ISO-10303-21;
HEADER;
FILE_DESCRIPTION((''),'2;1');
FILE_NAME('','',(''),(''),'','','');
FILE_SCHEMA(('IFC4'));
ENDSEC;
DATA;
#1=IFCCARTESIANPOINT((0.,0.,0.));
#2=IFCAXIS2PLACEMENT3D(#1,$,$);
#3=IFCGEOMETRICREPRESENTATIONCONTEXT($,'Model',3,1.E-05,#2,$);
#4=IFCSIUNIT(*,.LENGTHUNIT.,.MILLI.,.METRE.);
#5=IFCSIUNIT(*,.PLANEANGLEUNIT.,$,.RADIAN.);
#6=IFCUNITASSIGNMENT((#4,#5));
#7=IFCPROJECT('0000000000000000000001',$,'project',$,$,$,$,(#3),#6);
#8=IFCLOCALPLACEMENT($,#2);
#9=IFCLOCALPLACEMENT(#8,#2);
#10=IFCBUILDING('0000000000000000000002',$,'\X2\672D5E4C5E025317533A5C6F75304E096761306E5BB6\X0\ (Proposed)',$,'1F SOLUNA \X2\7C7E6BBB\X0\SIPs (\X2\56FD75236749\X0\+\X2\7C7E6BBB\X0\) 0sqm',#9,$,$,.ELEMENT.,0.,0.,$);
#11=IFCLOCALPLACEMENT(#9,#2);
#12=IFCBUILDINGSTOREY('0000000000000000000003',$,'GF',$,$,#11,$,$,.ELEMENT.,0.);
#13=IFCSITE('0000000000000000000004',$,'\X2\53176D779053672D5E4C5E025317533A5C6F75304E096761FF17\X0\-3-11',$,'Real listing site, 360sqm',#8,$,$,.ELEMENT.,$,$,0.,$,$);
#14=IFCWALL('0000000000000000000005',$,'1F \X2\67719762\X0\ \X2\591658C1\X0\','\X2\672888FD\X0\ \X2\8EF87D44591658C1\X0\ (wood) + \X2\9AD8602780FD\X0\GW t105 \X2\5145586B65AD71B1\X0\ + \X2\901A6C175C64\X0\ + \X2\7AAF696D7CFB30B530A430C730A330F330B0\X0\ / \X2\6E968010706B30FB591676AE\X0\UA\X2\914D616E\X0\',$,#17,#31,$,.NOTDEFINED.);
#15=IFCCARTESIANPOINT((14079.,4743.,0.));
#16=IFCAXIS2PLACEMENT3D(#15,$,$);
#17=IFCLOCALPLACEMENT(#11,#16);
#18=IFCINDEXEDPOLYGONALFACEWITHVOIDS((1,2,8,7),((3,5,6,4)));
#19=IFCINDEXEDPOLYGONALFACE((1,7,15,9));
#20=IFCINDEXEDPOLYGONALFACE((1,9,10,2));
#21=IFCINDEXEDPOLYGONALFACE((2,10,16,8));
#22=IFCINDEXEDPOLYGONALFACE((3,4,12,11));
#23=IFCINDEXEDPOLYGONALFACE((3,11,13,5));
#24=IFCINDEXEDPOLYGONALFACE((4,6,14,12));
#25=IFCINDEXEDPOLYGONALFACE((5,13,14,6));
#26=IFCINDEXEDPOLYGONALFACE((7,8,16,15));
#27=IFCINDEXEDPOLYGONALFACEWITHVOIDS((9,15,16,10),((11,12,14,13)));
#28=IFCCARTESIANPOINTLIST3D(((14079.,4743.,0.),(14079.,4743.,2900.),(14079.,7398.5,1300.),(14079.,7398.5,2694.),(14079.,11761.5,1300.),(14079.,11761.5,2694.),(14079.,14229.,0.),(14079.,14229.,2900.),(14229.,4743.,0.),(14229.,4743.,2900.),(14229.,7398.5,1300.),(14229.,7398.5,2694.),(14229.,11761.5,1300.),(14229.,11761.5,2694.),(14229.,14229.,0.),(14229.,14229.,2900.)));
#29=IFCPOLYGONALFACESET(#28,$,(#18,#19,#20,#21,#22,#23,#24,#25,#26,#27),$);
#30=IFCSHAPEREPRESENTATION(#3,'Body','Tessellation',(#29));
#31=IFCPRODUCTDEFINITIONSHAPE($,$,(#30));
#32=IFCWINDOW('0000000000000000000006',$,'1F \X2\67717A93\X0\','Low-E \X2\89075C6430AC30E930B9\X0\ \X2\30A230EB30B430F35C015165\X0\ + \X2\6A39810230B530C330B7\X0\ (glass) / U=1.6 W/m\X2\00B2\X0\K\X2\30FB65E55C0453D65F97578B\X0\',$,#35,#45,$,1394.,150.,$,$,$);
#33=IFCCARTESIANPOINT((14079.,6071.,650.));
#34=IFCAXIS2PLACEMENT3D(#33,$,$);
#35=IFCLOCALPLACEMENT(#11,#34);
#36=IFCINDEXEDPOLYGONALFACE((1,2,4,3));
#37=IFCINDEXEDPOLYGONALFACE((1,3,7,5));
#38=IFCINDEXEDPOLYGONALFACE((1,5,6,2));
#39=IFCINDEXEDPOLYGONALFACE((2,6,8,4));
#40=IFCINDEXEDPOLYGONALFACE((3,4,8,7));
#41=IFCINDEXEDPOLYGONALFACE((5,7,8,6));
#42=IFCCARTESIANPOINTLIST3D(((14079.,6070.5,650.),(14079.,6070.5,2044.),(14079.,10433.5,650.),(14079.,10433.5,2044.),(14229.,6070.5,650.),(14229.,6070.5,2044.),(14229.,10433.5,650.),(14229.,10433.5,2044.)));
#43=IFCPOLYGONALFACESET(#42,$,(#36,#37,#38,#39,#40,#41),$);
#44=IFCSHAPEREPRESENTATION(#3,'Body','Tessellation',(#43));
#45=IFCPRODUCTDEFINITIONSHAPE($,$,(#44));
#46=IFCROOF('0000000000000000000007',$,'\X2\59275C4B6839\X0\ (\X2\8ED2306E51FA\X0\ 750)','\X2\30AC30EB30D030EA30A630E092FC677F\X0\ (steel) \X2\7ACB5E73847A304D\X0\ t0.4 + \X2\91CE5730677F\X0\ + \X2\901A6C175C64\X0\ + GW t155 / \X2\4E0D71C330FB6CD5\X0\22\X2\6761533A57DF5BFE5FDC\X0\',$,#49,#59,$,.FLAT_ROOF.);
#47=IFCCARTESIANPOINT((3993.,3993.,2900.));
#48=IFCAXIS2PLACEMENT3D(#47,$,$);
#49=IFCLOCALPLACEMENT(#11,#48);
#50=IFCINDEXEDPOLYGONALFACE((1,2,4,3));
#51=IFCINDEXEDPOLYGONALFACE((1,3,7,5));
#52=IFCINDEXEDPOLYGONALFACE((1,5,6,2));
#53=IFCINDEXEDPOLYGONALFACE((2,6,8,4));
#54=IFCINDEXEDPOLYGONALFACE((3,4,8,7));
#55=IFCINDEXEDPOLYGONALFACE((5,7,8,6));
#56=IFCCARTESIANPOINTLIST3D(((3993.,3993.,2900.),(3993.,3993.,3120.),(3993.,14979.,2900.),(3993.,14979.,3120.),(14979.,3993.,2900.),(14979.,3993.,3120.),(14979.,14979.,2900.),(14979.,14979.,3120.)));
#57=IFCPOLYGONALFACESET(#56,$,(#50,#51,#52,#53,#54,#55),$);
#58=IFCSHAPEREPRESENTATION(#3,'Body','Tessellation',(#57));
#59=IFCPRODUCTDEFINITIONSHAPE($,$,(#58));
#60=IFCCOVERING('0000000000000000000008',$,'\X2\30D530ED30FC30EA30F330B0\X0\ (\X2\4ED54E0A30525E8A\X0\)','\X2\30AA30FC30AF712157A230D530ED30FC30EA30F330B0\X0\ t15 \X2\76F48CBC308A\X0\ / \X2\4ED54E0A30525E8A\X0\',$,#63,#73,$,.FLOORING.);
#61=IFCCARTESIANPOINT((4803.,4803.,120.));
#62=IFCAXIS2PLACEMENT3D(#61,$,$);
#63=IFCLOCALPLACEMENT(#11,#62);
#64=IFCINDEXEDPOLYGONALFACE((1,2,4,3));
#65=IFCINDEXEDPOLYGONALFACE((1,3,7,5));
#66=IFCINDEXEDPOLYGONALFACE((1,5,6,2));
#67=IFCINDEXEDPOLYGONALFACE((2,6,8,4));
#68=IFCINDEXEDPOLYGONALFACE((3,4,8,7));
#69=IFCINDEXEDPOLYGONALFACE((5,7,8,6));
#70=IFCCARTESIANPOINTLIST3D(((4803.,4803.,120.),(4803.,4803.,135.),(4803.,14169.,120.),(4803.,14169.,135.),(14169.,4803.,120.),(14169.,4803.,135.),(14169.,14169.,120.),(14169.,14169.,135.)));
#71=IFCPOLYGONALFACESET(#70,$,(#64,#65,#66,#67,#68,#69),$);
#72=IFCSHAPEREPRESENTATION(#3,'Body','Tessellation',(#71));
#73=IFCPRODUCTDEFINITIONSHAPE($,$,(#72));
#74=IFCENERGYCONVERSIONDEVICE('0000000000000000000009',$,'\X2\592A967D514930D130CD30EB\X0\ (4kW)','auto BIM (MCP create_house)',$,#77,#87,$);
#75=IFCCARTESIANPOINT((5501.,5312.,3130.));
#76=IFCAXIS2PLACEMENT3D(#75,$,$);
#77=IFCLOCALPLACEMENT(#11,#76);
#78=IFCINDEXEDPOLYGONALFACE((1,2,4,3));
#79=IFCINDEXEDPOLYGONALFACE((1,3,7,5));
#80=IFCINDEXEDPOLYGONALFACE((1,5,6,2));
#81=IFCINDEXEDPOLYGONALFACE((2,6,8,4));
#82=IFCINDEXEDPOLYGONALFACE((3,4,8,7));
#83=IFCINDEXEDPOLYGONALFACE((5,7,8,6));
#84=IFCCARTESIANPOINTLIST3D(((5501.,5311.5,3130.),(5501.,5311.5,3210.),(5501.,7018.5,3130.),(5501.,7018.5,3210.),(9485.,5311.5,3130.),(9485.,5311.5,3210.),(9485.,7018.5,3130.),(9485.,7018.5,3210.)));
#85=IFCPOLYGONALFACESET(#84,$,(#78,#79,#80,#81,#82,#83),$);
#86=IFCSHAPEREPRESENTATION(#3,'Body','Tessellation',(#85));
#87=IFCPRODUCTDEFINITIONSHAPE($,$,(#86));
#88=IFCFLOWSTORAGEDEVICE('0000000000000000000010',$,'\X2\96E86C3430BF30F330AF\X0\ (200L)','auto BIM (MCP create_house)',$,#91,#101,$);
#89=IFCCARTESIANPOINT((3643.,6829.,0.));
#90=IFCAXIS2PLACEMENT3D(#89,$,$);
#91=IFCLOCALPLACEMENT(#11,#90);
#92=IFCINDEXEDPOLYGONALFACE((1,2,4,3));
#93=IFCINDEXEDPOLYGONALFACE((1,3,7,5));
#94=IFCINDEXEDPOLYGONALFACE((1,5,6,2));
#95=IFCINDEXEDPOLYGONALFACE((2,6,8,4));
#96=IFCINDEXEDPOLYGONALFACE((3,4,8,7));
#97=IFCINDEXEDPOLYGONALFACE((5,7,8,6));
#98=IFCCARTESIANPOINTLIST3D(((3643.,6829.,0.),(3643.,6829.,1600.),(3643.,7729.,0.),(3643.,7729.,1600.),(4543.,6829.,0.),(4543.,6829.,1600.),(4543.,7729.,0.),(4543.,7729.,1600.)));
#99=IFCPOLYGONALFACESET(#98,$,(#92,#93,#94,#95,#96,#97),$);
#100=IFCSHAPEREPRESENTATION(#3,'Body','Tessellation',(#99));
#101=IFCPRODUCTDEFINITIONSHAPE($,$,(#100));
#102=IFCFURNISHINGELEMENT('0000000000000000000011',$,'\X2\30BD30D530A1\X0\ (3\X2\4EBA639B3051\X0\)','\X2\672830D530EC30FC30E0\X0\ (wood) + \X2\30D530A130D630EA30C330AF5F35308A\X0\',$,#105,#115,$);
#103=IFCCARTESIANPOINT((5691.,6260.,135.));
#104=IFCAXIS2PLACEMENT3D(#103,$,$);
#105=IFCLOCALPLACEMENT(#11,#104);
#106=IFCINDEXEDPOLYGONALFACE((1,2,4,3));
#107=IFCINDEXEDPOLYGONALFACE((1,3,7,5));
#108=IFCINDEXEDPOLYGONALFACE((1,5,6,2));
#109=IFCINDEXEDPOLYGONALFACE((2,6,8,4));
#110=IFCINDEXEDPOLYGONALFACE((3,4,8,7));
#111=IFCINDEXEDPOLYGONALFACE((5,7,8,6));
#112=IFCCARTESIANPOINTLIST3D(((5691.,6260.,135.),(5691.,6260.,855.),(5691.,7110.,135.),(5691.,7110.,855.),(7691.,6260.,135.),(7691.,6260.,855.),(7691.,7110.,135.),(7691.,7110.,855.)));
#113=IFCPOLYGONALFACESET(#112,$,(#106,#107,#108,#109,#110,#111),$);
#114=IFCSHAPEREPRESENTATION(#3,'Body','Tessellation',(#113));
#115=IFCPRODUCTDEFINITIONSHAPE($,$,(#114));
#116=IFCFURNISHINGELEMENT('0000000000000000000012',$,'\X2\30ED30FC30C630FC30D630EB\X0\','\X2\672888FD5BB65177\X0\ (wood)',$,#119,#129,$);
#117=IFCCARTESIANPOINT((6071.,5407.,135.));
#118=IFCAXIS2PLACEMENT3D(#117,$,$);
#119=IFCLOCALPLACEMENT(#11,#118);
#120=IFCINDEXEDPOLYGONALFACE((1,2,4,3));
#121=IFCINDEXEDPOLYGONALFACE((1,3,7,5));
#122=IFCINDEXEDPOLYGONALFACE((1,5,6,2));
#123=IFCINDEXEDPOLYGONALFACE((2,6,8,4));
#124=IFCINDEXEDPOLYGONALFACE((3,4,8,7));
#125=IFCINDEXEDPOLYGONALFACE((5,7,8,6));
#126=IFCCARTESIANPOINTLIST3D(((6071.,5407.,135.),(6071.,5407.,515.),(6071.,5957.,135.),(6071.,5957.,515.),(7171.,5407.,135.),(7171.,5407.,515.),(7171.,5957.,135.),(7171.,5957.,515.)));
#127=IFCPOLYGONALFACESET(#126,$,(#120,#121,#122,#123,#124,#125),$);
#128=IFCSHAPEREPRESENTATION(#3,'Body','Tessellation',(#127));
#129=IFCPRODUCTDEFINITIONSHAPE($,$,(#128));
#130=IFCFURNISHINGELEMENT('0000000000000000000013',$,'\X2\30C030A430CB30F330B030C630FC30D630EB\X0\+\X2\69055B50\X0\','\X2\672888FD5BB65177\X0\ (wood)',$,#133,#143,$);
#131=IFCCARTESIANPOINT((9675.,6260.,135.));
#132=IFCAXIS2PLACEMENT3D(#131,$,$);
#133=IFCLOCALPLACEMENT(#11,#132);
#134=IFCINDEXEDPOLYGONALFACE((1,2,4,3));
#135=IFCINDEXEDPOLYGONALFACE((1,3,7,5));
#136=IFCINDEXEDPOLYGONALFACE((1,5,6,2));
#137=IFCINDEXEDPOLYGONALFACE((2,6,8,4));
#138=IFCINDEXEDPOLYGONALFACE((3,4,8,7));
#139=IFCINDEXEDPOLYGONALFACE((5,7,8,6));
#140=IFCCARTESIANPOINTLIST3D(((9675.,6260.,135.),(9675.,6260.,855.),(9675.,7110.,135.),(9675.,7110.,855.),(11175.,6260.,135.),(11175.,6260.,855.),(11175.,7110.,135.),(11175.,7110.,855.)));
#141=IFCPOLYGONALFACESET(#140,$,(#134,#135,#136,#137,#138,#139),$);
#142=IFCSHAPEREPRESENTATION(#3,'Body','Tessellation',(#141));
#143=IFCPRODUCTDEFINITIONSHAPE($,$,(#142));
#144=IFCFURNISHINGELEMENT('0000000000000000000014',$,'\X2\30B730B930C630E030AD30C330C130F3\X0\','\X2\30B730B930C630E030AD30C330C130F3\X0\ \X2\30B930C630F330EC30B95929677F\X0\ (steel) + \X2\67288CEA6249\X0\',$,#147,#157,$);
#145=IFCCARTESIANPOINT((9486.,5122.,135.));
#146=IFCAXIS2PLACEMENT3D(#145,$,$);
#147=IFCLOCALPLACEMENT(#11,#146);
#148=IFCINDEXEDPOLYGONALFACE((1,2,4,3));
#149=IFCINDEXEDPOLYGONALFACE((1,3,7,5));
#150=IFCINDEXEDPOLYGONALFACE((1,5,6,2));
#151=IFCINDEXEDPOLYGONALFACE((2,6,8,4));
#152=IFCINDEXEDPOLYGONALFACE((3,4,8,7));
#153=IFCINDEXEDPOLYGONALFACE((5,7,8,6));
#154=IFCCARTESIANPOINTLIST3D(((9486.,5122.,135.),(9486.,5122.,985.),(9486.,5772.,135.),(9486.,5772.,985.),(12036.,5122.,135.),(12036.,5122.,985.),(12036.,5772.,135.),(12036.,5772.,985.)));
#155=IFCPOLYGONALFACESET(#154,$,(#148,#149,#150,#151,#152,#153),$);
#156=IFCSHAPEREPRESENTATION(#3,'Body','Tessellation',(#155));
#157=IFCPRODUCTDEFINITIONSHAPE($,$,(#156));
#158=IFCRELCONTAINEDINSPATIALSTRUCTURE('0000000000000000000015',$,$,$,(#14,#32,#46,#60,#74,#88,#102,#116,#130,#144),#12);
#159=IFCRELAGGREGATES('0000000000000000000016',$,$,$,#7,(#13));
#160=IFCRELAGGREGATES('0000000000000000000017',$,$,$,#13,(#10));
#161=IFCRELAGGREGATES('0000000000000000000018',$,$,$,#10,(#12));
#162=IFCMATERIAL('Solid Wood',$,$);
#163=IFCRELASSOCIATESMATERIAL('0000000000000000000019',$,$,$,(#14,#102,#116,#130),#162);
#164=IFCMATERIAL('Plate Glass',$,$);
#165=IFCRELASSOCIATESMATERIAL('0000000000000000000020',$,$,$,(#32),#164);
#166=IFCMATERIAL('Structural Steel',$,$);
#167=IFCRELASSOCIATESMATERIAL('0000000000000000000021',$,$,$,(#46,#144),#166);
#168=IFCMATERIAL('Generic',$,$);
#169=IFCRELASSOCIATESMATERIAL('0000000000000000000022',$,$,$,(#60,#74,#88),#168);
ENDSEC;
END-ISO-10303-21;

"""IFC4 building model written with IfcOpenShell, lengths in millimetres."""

from ifc_helpers import new_model, si_unit, frame, frame_2d, origin, place, context, project, spatial, rectangle, extrude, material, element, fill, save


model = new_model("IFC4")

# Units and contexts
model_context = context("Model", 3, precision=1e-05, world=origin())
ifc_project = project(units=[si_unit("LENGTHUNIT", "METRE", prefix="MILLI"), si_unit("PLANEANGLEUNIT", "RADIAN")], contexts=[model_context])

# Site, building, storey
site_placement = place(None, origin())
site = spatial("IfcSite", under=ifc_project, at=site_placement, Name="北海道札幌市北区屯田三条７-3-11", ObjectType="Real listing site, 360sqm", CompositionType="ELEMENT", RefElevation=0.0)
building_placement = place(site_placement, origin())
building = spatial("IfcBuilding", under=site, at=building_placement, Name="札幌市北区屯田三条の家 (Proposed)", ObjectType="1F SOLUNA 籾殻SIPs (国産杉+籾殻) 0sqm", CompositionType="ELEMENT", ElevationOfRefHeight=0.0, ElevationOfTerrain=0.0)
storey_placement = place(building_placement, origin())
storey = spatial("IfcBuildingStorey", under=building, at=storey_placement, Name="GF", CompositionType="ELEMENT", Elevation=0.0)

# Shared definitions
ifc_material_1 = material(Name="Solid Wood")

# Shared definitions
ifc_material_2 = material(Name="Plate Glass")

# Wall, opening, window
wall_1_placement = place(storey_placement, frame((14079.0, 4743.0, 0.0)))
wall_1 = element("IfcWall", 1, at=wall_1_placement, inside=storey, material=ifc_material_1, Name="1F 東面 外壁", Description="木製 軸組外壁 (wood) + 高性能GW t105 充填断熱 + 通気層 + 窯業系サイディング / 準耐火・外皮UA配慮", PredefinedType="NOTDEFINED", context=model_context, shape_type="SweptSolid", body=[
    extrude(rectangle(XDim=150.0, YDim=9486.0, at=frame_2d((75.0, 4743.0))), frame((14079.0, 4743.0, 0.0)), (0.0, 0.0, 1.0), 2900.0),
])
opening_1_placement = place(storey_placement, frame((14079.0, 6071.0, 650.0)))
opening_1 = element("IfcOpeningElement", 2, at=opening_1_placement, cuts=wall_1, PredefinedType="NOTDEFINED", context=model_context, shape_type="SweptSolid", body=[
    extrude(rectangle(XDim=150.0, YDim=4363.0, at=frame_2d((75.0, 2181.0))), frame((14079.0, 6071.0, 650.0)), (0.0, 0.0, 1.0), 1394.0),
])
window_1_placement = place(storey_placement, frame((14079.0, 6071.0, 650.0)))
window_1 = element("IfcWindow", 3, at=window_1_placement, inside=storey, material=ifc_material_2, Name="1F 東窓", Description="Low-E 複層ガラス アルゴン封入 + 樹脂サッシ (glass) / U=1.6 W/m²K・日射取得型", OverallHeight=1394.0, OverallWidth=150.0, context=model_context, shape_type="SweptSolid", body=[
    extrude(rectangle(XDim=150.0, YDim=4363.0, at=frame_2d((75.0, 2181.0))), frame((14079.0, 6071.0, 650.0)), (0.0, 0.0, 1.0), 1394.0),
])
fill(opening_1, window_1)

# Roof
ifc_material_3 = material(Name="Structural Steel")
roof_placement = place(storey_placement, frame((3993.0, 3993.0, 2900.0)))
element("IfcRoof", 4, at=roof_placement, inside=storey, material=ifc_material_3, Name="大屋根 (軒の出 750)", Description="ガルバリウム鋼板 (steel) 立平葺き t0.4 + 野地板 + 通気層 + GW t155 / 不燃・法22条区域対応", PredefinedType="FLAT_ROOF", context=model_context, shape_type="SweptSolid", body=[
    extrude(rectangle(XDim=10986.0, YDim=10986.0, at=frame_2d((5493.0, 5493.0))), frame((3993.0, 3993.0, 2900.0)), (0.0, 0.0, 1.0), 220.0),
])

# Covering
ifc_material_4 = material(Name="Generic")
covering_placement = place(storey_placement, frame((4803.0, 4803.0, 120.0)))
element("IfcCovering", 5, at=covering_placement, inside=storey, material=ifc_material_4, Name="フローリング (仕上げ床)", Description="オーク無垢フローリング t15 直貼り / 仕上げ床", PredefinedType="FLOORING", context=model_context, shape_type="SweptSolid", body=[
    extrude(rectangle(XDim=9366.0, YDim=9366.0, at=frame_2d((4683.0, 4683.0))), frame((4803.0, 4803.0, 120.0)), (0.0, 0.0, 1.0), 15.0),
])

# Energy conversion device
energy_conversion_device_placement = place(storey_placement, frame((5501.0, 5312.0, 3130.0)))
element("IfcEnergyConversionDevice", 6, at=energy_conversion_device_placement, inside=storey, material=ifc_material_4, Name="太陽光パネル (4kW)", Description="auto BIM (MCP create_house)", context=model_context, shape_type="SweptSolid", body=[
    extrude(rectangle(XDim=3984.0, YDim=1707.0, at=frame_2d((1992.0, 853.0))), frame((5501.0, 5312.0, 3130.0)), (0.0, 0.0, 1.0), 80.0),
])

# Flow storage device
flow_storage_device_placement = place(storey_placement, frame((3643.0, 6829.0, 0.0)))
element("IfcFlowStorageDevice", 7, at=flow_storage_device_placement, inside=storey, material=ifc_material_4, Name="雨水タンク (200L)", Description="auto BIM (MCP create_house)", context=model_context, shape_type="SweptSolid", body=[
    extrude(rectangle(XDim=900.0, YDim=900.0, at=frame_2d((450.0, 450.0))), frame((3643.0, 6829.0, 0.0)), (0.0, 0.0, 1.0), 1600.0),
])

# Furnishing elements
furnishing_1_placement = place(storey_placement, frame((5691.0, 6260.0, 135.0)))
element("IfcFurnishingElement", 8, at=furnishing_1_placement, inside=storey, material=ifc_material_1, Name="ソファ (3人掛け)", Description="木フレーム (wood) + ファブリック張り", context=model_context, shape_type="SweptSolid", body=[
    extrude(rectangle(XDim=2000.0, YDim=850.0, at=frame_2d((1000.0, 425.0))), frame((5691.0, 6260.0, 135.0)), (0.0, 0.0, 1.0), 720.0),
])
furnishing_2_placement = place(storey_placement, frame((6071.0, 5407.0, 135.0)))
element("IfcFurnishingElement", 9, at=furnishing_2_placement, inside=storey, material=ifc_material_1, Name="ローテーブル", Description="木製家具 (wood)", context=model_context, shape_type="SweptSolid", body=[
    extrude(rectangle(XDim=1100.0, YDim=550.0, at=frame_2d((550.0, 275.0))), frame((6071.0, 5407.0, 135.0)), (0.0, 0.0, 1.0), 380.0),
])
furnishing_3_placement = place(storey_placement, frame((9675.0, 6260.0, 135.0)))
element("IfcFurnishingElement", 10, at=furnishing_3_placement, inside=storey, material=ifc_material_1, Name="ダイニングテーブル+椅子", Description="木製家具 (wood)", context=model_context, shape_type="SweptSolid", body=[
    extrude(rectangle(XDim=1500.0, YDim=850.0, at=frame_2d((750.0, 425.0))), frame((9675.0, 6260.0, 135.0)), (0.0, 0.0, 1.0), 720.0),
])
furnishing_4_placement = place(storey_placement, frame((9486.0, 5122.0, 135.0)))
element("IfcFurnishingElement", 11, at=furnishing_4_placement, inside=storey, material=ifc_material_3, Name="システムキッチン", Description="システムキッチン ステンレス天板 (steel) + 木質扉", context=model_context, shape_type="SweptSolid", body=[
    extrude(rectangle(XDim=2550.0, YDim=650.0, at=frame_2d((1275.0, 325.0))), frame((9486.0, 5122.0, 135.0)), (0.0, 0.0, 1.0), 850.0),
])

save(model, "model.ifc")
